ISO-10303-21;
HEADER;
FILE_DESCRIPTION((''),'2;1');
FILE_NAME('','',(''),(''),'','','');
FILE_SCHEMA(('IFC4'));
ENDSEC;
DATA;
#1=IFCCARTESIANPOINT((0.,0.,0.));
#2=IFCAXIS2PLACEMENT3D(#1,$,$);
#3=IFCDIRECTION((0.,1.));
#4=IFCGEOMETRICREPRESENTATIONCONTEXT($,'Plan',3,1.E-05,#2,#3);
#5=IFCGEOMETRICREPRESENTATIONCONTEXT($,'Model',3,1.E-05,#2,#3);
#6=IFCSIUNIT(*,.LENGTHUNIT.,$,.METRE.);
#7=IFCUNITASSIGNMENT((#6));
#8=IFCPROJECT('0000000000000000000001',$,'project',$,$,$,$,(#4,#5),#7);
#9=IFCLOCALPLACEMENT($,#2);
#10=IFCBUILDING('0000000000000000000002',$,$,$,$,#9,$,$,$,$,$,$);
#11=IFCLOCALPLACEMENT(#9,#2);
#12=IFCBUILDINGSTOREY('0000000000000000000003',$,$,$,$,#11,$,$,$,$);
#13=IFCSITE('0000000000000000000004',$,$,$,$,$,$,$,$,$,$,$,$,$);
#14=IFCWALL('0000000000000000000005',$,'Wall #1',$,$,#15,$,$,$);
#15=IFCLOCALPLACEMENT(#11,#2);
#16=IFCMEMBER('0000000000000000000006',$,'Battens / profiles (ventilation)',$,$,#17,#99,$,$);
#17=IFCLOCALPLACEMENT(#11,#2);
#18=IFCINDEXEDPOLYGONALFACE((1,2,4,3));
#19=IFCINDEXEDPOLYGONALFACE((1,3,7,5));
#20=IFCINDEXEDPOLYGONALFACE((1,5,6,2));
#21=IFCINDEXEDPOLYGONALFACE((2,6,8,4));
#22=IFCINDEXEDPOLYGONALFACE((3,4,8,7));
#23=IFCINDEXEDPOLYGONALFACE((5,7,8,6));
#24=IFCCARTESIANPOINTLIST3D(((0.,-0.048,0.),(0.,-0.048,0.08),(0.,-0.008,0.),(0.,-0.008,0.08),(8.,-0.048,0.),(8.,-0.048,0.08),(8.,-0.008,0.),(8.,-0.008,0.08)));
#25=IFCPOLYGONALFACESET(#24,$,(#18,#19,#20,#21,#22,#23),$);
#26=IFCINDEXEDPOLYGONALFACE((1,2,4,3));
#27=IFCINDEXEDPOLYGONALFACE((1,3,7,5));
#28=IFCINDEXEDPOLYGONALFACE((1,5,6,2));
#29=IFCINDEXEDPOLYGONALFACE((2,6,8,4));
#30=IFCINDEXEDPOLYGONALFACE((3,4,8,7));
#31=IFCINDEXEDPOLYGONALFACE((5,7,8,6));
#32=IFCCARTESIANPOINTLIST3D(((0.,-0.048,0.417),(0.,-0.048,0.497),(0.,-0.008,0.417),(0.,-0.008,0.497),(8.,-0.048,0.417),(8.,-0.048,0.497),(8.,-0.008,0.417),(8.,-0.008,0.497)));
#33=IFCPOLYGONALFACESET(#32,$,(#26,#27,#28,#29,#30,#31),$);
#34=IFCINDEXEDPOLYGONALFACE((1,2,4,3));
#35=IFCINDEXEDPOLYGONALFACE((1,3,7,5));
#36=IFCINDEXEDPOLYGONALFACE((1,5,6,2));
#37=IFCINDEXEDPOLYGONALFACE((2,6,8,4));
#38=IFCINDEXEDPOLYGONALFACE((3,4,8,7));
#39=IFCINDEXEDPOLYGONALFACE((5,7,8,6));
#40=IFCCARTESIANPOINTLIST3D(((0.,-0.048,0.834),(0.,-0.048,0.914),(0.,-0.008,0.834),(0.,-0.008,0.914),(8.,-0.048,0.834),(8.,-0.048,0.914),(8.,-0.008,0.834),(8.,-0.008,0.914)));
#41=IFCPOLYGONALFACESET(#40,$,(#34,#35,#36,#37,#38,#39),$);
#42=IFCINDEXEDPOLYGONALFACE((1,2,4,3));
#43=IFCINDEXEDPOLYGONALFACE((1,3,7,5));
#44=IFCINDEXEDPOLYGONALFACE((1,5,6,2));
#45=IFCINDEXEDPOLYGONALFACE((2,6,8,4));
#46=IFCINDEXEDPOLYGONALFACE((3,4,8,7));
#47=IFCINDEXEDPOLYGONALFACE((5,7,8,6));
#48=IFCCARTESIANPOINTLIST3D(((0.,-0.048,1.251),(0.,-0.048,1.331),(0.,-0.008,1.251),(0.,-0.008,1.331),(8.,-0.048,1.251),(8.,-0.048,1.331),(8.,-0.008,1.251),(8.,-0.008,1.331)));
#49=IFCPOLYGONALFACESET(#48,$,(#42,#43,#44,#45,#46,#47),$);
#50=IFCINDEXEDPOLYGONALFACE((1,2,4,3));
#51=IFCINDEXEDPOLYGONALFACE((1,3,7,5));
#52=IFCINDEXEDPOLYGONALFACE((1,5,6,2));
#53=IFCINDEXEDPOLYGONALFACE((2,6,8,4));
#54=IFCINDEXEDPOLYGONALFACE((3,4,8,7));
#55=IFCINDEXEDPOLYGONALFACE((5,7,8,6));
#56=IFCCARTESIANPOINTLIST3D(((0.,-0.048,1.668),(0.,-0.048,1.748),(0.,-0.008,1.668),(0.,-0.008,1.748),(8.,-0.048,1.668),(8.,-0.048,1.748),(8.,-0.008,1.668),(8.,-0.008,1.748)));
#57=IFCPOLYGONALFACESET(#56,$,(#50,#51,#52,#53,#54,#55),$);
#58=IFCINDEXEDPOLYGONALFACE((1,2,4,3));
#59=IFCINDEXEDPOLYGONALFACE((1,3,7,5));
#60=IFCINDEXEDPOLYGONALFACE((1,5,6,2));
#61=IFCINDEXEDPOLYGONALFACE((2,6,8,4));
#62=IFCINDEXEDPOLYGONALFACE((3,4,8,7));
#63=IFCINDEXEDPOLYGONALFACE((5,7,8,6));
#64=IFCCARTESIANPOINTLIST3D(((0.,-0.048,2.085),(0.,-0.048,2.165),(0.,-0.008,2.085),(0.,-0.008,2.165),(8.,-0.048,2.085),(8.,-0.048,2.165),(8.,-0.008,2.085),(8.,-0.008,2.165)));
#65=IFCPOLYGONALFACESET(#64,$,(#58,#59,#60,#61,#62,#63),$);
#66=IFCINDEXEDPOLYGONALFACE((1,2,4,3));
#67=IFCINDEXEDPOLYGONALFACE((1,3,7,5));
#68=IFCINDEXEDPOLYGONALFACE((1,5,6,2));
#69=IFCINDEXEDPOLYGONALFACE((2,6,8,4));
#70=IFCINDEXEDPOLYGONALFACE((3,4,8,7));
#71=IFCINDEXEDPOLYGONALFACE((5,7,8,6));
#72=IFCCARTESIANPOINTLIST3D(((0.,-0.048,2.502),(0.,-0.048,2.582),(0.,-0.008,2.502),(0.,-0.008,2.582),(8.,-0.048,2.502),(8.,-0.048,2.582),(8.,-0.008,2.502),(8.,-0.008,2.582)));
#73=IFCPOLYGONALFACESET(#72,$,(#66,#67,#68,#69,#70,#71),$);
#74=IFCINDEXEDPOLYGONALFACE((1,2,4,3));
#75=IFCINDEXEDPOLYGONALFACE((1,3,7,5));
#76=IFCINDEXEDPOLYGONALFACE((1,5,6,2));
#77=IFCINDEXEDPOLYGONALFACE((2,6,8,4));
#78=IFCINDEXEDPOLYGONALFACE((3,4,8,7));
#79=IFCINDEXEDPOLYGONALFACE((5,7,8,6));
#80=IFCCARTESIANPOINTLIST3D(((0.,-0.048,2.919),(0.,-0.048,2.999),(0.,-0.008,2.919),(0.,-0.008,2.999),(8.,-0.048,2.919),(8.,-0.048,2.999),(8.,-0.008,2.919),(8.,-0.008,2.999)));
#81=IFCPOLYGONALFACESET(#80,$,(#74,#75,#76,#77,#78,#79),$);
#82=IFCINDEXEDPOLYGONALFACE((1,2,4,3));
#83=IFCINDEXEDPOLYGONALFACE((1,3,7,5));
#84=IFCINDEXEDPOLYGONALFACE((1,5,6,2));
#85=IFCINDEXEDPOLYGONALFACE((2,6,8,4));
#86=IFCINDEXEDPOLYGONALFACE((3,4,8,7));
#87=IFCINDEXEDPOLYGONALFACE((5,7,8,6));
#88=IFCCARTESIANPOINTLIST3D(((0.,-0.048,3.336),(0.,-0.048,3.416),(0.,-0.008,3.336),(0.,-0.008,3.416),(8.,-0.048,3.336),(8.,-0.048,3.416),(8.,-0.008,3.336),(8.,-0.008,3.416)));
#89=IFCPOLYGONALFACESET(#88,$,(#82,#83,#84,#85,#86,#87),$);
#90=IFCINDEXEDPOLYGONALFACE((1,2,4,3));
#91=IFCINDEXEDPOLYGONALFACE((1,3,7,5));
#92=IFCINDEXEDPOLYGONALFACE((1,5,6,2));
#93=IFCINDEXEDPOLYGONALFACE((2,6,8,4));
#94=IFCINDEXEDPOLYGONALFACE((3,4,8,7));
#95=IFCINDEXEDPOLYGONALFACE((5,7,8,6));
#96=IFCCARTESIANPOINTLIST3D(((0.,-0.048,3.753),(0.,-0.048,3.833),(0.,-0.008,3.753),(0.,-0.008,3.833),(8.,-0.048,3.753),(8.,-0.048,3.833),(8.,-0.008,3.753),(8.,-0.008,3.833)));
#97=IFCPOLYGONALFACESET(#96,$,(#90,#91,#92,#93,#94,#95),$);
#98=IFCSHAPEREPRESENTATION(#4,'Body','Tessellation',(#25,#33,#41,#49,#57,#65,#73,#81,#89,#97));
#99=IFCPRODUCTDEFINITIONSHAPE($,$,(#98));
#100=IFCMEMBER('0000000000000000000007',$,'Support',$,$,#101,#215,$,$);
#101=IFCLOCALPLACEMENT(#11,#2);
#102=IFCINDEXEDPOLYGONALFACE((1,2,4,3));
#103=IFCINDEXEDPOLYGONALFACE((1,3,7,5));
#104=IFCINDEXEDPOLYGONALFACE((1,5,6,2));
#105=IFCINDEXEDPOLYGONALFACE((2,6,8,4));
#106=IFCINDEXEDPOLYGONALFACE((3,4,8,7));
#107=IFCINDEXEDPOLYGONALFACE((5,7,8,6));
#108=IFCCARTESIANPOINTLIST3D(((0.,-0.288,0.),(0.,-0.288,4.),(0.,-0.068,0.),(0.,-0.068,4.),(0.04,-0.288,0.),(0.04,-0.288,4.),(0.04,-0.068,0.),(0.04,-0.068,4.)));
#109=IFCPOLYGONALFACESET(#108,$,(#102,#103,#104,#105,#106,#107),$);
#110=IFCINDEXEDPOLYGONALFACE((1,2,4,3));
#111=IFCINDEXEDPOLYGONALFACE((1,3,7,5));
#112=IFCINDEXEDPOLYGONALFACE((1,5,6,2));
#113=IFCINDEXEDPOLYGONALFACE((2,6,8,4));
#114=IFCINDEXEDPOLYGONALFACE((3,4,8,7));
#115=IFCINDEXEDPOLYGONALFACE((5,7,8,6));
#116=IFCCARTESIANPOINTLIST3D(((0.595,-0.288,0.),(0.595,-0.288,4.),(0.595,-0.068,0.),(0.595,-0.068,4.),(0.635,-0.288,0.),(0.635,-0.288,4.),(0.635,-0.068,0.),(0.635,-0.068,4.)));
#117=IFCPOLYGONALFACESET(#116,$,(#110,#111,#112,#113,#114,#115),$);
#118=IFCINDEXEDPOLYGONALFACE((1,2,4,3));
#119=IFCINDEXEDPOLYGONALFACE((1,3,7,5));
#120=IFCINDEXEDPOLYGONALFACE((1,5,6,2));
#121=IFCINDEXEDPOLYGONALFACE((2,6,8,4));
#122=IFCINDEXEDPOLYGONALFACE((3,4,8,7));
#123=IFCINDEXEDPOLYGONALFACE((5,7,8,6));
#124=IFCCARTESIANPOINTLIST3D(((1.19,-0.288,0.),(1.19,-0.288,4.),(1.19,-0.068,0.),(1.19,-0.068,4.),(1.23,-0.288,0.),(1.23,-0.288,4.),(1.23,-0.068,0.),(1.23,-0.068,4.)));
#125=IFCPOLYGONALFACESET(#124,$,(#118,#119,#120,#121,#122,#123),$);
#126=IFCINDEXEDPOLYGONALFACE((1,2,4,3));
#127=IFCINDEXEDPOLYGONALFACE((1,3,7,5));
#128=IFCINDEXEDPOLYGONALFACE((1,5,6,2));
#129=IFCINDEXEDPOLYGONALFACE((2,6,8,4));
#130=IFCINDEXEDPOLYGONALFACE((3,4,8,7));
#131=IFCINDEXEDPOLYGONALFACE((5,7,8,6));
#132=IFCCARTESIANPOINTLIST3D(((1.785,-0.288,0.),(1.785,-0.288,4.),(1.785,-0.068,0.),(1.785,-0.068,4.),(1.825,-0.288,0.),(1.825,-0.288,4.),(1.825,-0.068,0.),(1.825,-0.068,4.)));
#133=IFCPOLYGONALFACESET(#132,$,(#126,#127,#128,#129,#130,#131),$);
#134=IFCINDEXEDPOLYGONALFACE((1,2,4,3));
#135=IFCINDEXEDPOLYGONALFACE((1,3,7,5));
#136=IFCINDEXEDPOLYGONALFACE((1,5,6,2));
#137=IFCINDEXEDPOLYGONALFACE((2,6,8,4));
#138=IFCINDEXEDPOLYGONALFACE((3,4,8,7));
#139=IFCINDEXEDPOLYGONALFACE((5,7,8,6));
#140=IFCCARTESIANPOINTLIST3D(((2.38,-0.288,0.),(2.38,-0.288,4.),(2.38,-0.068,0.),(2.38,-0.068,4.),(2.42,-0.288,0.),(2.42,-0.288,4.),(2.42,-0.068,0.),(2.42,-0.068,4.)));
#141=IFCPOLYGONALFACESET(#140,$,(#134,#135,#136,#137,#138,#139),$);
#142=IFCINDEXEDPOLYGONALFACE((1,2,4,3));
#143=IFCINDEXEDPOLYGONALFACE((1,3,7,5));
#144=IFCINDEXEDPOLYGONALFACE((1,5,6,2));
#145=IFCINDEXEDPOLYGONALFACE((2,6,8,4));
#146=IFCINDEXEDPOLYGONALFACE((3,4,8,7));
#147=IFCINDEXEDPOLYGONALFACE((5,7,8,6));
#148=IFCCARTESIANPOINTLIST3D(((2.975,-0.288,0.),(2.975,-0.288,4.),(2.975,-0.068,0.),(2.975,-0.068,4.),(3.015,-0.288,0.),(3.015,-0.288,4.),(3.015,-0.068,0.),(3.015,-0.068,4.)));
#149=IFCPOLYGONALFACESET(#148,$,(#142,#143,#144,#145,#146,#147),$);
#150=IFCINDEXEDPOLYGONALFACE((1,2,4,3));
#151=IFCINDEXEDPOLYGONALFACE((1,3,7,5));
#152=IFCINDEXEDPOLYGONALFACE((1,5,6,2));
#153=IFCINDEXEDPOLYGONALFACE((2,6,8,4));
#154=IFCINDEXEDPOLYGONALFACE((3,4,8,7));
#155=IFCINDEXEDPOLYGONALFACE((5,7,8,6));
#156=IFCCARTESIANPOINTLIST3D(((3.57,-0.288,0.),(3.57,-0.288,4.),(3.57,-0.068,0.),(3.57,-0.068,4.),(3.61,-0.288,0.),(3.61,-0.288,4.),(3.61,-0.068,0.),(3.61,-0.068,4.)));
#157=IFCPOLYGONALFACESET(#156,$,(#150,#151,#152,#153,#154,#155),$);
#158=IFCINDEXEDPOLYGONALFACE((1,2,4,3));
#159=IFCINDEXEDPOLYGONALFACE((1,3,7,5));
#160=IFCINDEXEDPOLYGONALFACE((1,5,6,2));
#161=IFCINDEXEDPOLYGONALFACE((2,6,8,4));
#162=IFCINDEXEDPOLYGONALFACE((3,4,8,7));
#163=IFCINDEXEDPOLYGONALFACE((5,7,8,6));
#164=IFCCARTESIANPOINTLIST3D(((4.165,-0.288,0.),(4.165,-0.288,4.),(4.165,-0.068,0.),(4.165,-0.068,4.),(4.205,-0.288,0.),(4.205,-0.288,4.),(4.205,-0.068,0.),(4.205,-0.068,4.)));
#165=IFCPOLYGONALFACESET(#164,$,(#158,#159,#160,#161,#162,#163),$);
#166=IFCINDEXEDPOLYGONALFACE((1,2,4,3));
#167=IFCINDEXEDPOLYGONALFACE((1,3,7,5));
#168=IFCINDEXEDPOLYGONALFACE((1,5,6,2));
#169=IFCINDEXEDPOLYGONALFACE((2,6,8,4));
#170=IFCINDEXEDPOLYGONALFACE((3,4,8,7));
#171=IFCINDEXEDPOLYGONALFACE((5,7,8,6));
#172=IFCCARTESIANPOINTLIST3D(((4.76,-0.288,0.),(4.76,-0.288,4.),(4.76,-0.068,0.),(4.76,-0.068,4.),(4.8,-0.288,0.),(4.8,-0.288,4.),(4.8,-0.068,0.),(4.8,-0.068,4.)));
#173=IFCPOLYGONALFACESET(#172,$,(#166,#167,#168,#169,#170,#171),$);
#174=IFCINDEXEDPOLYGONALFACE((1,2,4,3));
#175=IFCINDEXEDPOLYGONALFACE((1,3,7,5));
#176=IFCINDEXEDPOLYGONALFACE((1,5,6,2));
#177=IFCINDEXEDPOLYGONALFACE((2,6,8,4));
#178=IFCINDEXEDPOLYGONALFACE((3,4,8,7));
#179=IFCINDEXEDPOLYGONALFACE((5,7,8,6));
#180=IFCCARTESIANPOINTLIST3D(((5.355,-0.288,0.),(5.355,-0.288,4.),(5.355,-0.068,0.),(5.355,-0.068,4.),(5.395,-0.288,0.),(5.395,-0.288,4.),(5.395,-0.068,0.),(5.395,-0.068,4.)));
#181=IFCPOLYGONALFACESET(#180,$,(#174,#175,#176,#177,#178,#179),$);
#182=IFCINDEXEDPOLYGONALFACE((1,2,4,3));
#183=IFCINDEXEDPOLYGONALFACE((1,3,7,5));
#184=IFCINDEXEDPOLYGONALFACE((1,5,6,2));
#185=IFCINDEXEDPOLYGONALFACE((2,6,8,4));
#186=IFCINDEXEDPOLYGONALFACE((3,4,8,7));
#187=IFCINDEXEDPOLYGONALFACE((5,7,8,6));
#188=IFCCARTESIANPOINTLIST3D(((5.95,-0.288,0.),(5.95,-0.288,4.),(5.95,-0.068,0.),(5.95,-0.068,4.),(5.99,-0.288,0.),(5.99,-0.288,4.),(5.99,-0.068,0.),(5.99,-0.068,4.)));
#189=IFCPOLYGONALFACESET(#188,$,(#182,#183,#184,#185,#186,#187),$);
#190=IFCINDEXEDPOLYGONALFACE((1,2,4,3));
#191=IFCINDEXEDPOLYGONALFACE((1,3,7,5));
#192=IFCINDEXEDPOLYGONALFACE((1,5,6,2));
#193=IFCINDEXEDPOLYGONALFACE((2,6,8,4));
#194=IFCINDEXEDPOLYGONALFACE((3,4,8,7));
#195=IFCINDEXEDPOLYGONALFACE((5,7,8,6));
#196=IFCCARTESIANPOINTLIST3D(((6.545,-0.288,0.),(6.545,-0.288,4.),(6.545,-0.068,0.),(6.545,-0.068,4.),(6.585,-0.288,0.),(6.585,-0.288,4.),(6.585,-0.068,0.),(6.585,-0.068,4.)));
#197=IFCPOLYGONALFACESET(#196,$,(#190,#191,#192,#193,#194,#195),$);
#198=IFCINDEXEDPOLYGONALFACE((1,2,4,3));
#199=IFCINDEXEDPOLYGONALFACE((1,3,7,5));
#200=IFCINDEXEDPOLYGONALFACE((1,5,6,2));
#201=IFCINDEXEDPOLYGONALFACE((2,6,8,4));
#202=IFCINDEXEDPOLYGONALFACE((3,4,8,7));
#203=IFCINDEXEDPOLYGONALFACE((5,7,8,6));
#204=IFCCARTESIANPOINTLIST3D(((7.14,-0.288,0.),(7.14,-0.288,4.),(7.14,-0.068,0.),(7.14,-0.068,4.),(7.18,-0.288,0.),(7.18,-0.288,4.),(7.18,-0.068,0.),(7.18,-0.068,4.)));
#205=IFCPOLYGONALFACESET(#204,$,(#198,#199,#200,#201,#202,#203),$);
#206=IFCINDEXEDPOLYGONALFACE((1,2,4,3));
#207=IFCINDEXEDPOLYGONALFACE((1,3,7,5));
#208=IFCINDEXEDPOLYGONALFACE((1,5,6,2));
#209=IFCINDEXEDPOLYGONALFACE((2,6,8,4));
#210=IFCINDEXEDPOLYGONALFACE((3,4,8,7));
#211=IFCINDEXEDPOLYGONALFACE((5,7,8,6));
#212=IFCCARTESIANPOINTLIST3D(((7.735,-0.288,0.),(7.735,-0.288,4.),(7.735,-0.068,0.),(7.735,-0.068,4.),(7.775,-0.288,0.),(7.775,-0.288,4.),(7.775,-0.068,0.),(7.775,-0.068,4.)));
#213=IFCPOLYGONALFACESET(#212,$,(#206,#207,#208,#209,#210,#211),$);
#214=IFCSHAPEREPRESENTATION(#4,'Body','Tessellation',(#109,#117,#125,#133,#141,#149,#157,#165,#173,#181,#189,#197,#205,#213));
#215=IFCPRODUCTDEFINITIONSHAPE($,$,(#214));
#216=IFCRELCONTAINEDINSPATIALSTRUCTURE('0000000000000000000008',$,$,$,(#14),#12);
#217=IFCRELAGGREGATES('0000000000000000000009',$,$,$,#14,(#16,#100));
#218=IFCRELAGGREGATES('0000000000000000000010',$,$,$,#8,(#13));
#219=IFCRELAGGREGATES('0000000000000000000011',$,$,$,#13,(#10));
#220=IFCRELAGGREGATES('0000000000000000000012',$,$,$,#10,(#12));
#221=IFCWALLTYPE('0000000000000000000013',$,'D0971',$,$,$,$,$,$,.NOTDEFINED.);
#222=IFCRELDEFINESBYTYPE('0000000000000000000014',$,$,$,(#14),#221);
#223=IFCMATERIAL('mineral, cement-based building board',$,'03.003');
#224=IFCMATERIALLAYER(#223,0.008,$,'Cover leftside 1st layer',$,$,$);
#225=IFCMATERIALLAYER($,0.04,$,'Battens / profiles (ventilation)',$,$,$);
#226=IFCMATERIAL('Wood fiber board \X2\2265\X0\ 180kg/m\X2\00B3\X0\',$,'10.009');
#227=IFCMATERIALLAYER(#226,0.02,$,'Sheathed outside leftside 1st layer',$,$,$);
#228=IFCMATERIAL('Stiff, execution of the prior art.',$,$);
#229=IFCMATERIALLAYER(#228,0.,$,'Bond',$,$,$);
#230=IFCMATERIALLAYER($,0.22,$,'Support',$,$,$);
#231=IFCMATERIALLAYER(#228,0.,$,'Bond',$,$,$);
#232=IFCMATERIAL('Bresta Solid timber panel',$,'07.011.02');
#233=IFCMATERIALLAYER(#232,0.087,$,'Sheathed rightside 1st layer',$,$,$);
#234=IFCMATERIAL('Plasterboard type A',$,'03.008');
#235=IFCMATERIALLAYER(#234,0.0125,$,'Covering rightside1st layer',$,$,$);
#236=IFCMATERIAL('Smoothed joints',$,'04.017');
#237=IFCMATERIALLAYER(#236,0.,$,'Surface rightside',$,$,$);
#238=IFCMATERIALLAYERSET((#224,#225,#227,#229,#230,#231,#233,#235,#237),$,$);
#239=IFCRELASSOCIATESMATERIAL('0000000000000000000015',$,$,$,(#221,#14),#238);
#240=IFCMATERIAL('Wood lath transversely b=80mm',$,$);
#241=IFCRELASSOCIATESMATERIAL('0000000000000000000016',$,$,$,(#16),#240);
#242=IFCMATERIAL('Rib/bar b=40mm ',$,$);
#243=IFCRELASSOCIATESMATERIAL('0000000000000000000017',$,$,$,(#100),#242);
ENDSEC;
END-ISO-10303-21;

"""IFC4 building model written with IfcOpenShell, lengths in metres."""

from ifc_helpers import new_model, si_unit, direction, frame, frame_2d, origin, place, context, project, spatial, rectangle, extrude, material, layer, layer_set, type_object, element, aggregate, save


model = new_model("IFC4")

# Units and contexts
plan_context = context("Plan", 3, precision=1e-05, world=origin(), true_north=direction((0.0, 1.0)))
model_context = context("Model", 3, precision=1e-05, world=origin(), true_north=direction((0.0, 1.0)))
ifc_project = project(units=[si_unit("LENGTHUNIT", "METRE")], contexts=[plan_context, model_context])

# Site, building, storey
site = spatial("IfcSite", under=ifc_project)
building_placement = place(None, origin())
building = spatial("IfcBuilding", under=site, at=building_placement)
storey_placement = place(building_placement, origin())
storey = spatial("IfcBuildingStorey", under=building, at=storey_placement)

# Wall, members
ifc_material_1 = material(Name="mineral, cement-based building board", Category="03.003")
ifc_layer_1 = layer(ifc_material_1, 0.008, Name="Cover leftside 1st layer")
ifc_layer_2 = layer(None, 0.04, Name="Battens / profiles (ventilation)")
ifc_material_2 = material(Name="Wood fiber board ≥ 180kg/m³", Category="10.009")
ifc_layer_3 = layer(ifc_material_2, 0.02, Name="Sheathed outside leftside 1st layer")
ifc_material_3 = material(Name="Stiff, execution of the prior art.")
ifc_layer_4 = layer(ifc_material_3, 0.0, Name="Bond")
ifc_layer_5 = layer(None, 0.22, Name="Support")
ifc_layer_6 = layer(ifc_material_3, 0.0, Name="Bond")
ifc_material_4 = material(Name="Bresta Solid timber panel", Category="07.011.02")
ifc_layer_7 = layer(ifc_material_4, 0.087, Name="Sheathed rightside 1st layer")
ifc_material_5 = material(Name="Plasterboard type A", Category="03.008")
ifc_layer_8 = layer(ifc_material_5, 0.0125, Name="Covering rightside1st layer")
ifc_material_6 = material(Name="Smoothed joints", Category="04.017")
ifc_layer_9 = layer(ifc_material_6, 0.0, Name="Surface rightside")
ifc_layer_set = layer_set([ifc_layer_1, ifc_layer_2, ifc_layer_3, ifc_layer_4, ifc_layer_5, ifc_layer_6, ifc_layer_7, ifc_layer_8, ifc_layer_9])
wall_type = type_object("IfcWallType", Name="D0971", PredefinedType="NOTDEFINED", material=ifc_layer_set)
wall_placement = place(None, frame((0.0, 0.0, 0.0), z_axis=(0.0, -1.0, 0.0), x_axis=(1.0, 0.0, 0.0)))
wall = element("IfcWall", 1, at=wall_placement, inside=storey, type_object=wall_type, material=ifc_layer_set, Name="Wall #1")
ifc_material_7 = material(Name="Wood lath transversely b=80mm")
member_1_placement = place(wall_placement, origin())
member_1 = element("IfcMember", 2, at=member_1_placement, material=ifc_material_7, Name="Battens / profiles (ventilation)", context=plan_context, shape_type="SweptSolid", body=[
    extrude(rectangle(XDim=0.08, YDim=0.04, at=frame_2d((0.04, 0.02), x_axis=(1.0, 0.0))), frame((0.0, 0.0, 0.008), z_axis=(1.0, 0.0, 0.0), x_axis=(0.0, 1.0, 0.0)), (0.0, 0.0, 1.0), 8.0),
    extrude(rectangle(XDim=0.08, YDim=0.04, at=frame_2d((0.04, 0.02), x_axis=(1.0, 0.0))), frame((0.0, 0.417, 0.008), z_axis=(1.0, 0.0, 0.0), x_axis=(0.0, 1.0, 0.0)), (0.0, 0.0, 1.0), 8.0),
    extrude(rectangle(XDim=0.08, YDim=0.04, at=frame_2d((0.04, 0.02), x_axis=(1.0, 0.0))), frame((0.0, 0.834, 0.008), z_axis=(1.0, 0.0, 0.0), x_axis=(0.0, 1.0, 0.0)), (0.0, 0.0, 1.0), 8.0),
    extrude(rectangle(XDim=0.08, YDim=0.04, at=frame_2d((0.04, 0.02), x_axis=(1.0, 0.0))), frame((0.0, 1.251, 0.008), z_axis=(1.0, 0.0, 0.0), x_axis=(0.0, 1.0, 0.0)), (0.0, 0.0, 1.0), 8.0),
    extrude(rectangle(XDim=0.08, YDim=0.04, at=frame_2d((0.04, 0.02), x_axis=(1.0, 0.0))), frame((0.0, 1.668, 0.008), z_axis=(1.0, 0.0, 0.0), x_axis=(0.0, 1.0, 0.0)), (0.0, 0.0, 1.0), 8.0),
    extrude(rectangle(XDim=0.08, YDim=0.04, at=frame_2d((0.04, 0.02), x_axis=(1.0, 0.0))), frame((0.0, 2.085, 0.008), z_axis=(1.0, 0.0, 0.0), x_axis=(0.0, 1.0, 0.0)), (0.0, 0.0, 1.0), 8.0),
    extrude(rectangle(XDim=0.08, YDim=0.04, at=frame_2d((0.04, 0.02), x_axis=(1.0, 0.0))), frame((0.0, 2.502, 0.008), z_axis=(1.0, 0.0, 0.0), x_axis=(0.0, 1.0, 0.0)), (0.0, 0.0, 1.0), 8.0),
    extrude(rectangle(XDim=0.08, YDim=0.04, at=frame_2d((0.04, 0.02), x_axis=(1.0, 0.0))), frame((0.0, 2.919, 0.008), z_axis=(1.0, 0.0, 0.0), x_axis=(0.0, 1.0, 0.0)), (0.0, 0.0, 1.0), 8.0),
    extrude(rectangle(XDim=0.08, YDim=0.04, at=frame_2d((0.04, 0.02), x_axis=(1.0, 0.0))), frame((0.0, 3.336, 0.008), z_axis=(1.0, 0.0, 0.0), x_axis=(0.0, 1.0, 0.0)), (0.0, 0.0, 1.0), 8.0),
    extrude(rectangle(XDim=0.08, YDim=0.04, at=frame_2d((0.04, 0.02), x_axis=(1.0, 0.0))), frame((0.0, 3.753, 0.008), z_axis=(1.0, 0.0, 0.0), x_axis=(0.0, 1.0, 0.0)), (0.0, 0.0, 1.0), 8.0),
])
ifc_material_8 = material(Name="Rib/bar b=40mm ")
member_2_placement = place(wall_placement, origin())
member_2 = element("IfcMember", 3, at=member_2_placement, material=ifc_material_8, Name="Support", context=plan_context, shape_type="SweptSolid", body=[
    extrude(rectangle(XDim=0.04, YDim=0.22, at=frame_2d((0.02, 0.11), x_axis=(1.0, 0.0))), frame((0.0, 4.0, 0.068), z_axis=(0.0, -1.0, 0.0), x_axis=(1.0, 0.0, 0.0)), (0.0, 0.0, 1.0), 4.0),
    extrude(rectangle(XDim=0.04, YDim=0.22, at=frame_2d((0.02, 0.11), x_axis=(1.0, 0.0))), frame((0.595, 4.0, 0.068), z_axis=(0.0, -1.0, 0.0), x_axis=(1.0, 0.0, 0.0)), (0.0, 0.0, 1.0), 4.0),
    extrude(rectangle(XDim=0.04, YDim=0.22, at=frame_2d((0.02, 0.11), x_axis=(1.0, 0.0))), frame((1.19, 4.0, 0.068), z_axis=(0.0, -1.0, 0.0), x_axis=(1.0, 0.0, 0.0)), (0.0, 0.0, 1.0), 4.0),
    extrude(rectangle(XDim=0.04, YDim=0.22, at=frame_2d((0.02, 0.11), x_axis=(1.0, 0.0))), frame((1.785, 4.0, 0.068), z_axis=(0.0, -1.0, 0.0), x_axis=(1.0, 0.0, 0.0)), (0.0, 0.0, 1.0), 4.0),
    extrude(rectangle(XDim=0.04, YDim=0.22, at=frame_2d((0.02, 0.11), x_axis=(1.0, 0.0))), frame((2.38, 4.0, 0.068), z_axis=(0.0, -1.0, 0.0), x_axis=(1.0, 0.0, 0.0)), (0.0, 0.0, 1.0), 4.0),
    extrude(rectangle(XDim=0.04, YDim=0.22, at=frame_2d((0.02, 0.11), x_axis=(1.0, 0.0))), frame((2.975, 4.0, 0.068), z_axis=(0.0, -1.0, 0.0), x_axis=(1.0, 0.0, 0.0)), (0.0, 0.0, 1.0), 4.0),
    extrude(rectangle(XDim=0.04, YDim=0.22, at=frame_2d((0.02, 0.11), x_axis=(1.0, 0.0))), frame((3.57, 4.0, 0.068), z_axis=(0.0, -1.0, 0.0), x_axis=(1.0, 0.0, 0.0)), (0.0, 0.0, 1.0), 4.0),
    extrude(rectangle(XDim=0.04, YDim=0.22, at=frame_2d((0.02, 0.11), x_axis=(1.0, 0.0))), frame((4.165, 4.0, 0.068), z_axis=(0.0, -1.0, 0.0), x_axis=(1.0, 0.0, 0.0)), (0.0, 0.0, 1.0), 4.0),
    extrude(rectangle(XDim=0.04, YDim=0.22, at=frame_2d((0.02, 0.11), x_axis=(1.0, 0.0))), frame((4.76, 4.0, 0.068), z_axis=(0.0, -1.0, 0.0), x_axis=(1.0, 0.0, 0.0)), (0.0, 0.0, 1.0), 4.0),
    extrude(rectangle(XDim=0.04, YDim=0.22, at=frame_2d((0.02, 0.11), x_axis=(1.0, 0.0))), frame((5.355, 4.0, 0.068), z_axis=(0.0, -1.0, 0.0), x_axis=(1.0, 0.0, 0.0)), (0.0, 0.0, 1.0), 4.0),
    extrude(rectangle(XDim=0.04, YDim=0.22, at=frame_2d((0.02, 0.11), x_axis=(1.0, 0.0))), frame((5.95, 4.0, 0.068), z_axis=(0.0, -1.0, 0.0), x_axis=(1.0, 0.0, 0.0)), (0.0, 0.0, 1.0), 4.0),
    extrude(rectangle(XDim=0.04, YDim=0.22, at=frame_2d((0.02, 0.11), x_axis=(1.0, 0.0))), frame((6.545, 4.0, 0.068), z_axis=(0.0, -1.0, 0.0), x_axis=(1.0, 0.0, 0.0)), (0.0, 0.0, 1.0), 4.0),
    extrude(rectangle(XDim=0.04, YDim=0.22, at=frame_2d((0.02, 0.11), x_axis=(1.0, 0.0))), frame((7.14, 4.0, 0.068), z_axis=(0.0, -1.0, 0.0), x_axis=(1.0, 0.0, 0.0)), (0.0, 0.0, 1.0), 4.0),
    extrude(rectangle(XDim=0.04, YDim=0.22, at=frame_2d((0.02, 0.11), x_axis=(1.0, 0.0))), frame((7.735, 4.0, 0.068), z_axis=(0.0, -1.0, 0.0), x_axis=(1.0, 0.0, 0.0)), (0.0, 0.0, 1.0), 4.0),
])
aggregate(wall, [member_1, member_2])

save(model, "model.ifc")
